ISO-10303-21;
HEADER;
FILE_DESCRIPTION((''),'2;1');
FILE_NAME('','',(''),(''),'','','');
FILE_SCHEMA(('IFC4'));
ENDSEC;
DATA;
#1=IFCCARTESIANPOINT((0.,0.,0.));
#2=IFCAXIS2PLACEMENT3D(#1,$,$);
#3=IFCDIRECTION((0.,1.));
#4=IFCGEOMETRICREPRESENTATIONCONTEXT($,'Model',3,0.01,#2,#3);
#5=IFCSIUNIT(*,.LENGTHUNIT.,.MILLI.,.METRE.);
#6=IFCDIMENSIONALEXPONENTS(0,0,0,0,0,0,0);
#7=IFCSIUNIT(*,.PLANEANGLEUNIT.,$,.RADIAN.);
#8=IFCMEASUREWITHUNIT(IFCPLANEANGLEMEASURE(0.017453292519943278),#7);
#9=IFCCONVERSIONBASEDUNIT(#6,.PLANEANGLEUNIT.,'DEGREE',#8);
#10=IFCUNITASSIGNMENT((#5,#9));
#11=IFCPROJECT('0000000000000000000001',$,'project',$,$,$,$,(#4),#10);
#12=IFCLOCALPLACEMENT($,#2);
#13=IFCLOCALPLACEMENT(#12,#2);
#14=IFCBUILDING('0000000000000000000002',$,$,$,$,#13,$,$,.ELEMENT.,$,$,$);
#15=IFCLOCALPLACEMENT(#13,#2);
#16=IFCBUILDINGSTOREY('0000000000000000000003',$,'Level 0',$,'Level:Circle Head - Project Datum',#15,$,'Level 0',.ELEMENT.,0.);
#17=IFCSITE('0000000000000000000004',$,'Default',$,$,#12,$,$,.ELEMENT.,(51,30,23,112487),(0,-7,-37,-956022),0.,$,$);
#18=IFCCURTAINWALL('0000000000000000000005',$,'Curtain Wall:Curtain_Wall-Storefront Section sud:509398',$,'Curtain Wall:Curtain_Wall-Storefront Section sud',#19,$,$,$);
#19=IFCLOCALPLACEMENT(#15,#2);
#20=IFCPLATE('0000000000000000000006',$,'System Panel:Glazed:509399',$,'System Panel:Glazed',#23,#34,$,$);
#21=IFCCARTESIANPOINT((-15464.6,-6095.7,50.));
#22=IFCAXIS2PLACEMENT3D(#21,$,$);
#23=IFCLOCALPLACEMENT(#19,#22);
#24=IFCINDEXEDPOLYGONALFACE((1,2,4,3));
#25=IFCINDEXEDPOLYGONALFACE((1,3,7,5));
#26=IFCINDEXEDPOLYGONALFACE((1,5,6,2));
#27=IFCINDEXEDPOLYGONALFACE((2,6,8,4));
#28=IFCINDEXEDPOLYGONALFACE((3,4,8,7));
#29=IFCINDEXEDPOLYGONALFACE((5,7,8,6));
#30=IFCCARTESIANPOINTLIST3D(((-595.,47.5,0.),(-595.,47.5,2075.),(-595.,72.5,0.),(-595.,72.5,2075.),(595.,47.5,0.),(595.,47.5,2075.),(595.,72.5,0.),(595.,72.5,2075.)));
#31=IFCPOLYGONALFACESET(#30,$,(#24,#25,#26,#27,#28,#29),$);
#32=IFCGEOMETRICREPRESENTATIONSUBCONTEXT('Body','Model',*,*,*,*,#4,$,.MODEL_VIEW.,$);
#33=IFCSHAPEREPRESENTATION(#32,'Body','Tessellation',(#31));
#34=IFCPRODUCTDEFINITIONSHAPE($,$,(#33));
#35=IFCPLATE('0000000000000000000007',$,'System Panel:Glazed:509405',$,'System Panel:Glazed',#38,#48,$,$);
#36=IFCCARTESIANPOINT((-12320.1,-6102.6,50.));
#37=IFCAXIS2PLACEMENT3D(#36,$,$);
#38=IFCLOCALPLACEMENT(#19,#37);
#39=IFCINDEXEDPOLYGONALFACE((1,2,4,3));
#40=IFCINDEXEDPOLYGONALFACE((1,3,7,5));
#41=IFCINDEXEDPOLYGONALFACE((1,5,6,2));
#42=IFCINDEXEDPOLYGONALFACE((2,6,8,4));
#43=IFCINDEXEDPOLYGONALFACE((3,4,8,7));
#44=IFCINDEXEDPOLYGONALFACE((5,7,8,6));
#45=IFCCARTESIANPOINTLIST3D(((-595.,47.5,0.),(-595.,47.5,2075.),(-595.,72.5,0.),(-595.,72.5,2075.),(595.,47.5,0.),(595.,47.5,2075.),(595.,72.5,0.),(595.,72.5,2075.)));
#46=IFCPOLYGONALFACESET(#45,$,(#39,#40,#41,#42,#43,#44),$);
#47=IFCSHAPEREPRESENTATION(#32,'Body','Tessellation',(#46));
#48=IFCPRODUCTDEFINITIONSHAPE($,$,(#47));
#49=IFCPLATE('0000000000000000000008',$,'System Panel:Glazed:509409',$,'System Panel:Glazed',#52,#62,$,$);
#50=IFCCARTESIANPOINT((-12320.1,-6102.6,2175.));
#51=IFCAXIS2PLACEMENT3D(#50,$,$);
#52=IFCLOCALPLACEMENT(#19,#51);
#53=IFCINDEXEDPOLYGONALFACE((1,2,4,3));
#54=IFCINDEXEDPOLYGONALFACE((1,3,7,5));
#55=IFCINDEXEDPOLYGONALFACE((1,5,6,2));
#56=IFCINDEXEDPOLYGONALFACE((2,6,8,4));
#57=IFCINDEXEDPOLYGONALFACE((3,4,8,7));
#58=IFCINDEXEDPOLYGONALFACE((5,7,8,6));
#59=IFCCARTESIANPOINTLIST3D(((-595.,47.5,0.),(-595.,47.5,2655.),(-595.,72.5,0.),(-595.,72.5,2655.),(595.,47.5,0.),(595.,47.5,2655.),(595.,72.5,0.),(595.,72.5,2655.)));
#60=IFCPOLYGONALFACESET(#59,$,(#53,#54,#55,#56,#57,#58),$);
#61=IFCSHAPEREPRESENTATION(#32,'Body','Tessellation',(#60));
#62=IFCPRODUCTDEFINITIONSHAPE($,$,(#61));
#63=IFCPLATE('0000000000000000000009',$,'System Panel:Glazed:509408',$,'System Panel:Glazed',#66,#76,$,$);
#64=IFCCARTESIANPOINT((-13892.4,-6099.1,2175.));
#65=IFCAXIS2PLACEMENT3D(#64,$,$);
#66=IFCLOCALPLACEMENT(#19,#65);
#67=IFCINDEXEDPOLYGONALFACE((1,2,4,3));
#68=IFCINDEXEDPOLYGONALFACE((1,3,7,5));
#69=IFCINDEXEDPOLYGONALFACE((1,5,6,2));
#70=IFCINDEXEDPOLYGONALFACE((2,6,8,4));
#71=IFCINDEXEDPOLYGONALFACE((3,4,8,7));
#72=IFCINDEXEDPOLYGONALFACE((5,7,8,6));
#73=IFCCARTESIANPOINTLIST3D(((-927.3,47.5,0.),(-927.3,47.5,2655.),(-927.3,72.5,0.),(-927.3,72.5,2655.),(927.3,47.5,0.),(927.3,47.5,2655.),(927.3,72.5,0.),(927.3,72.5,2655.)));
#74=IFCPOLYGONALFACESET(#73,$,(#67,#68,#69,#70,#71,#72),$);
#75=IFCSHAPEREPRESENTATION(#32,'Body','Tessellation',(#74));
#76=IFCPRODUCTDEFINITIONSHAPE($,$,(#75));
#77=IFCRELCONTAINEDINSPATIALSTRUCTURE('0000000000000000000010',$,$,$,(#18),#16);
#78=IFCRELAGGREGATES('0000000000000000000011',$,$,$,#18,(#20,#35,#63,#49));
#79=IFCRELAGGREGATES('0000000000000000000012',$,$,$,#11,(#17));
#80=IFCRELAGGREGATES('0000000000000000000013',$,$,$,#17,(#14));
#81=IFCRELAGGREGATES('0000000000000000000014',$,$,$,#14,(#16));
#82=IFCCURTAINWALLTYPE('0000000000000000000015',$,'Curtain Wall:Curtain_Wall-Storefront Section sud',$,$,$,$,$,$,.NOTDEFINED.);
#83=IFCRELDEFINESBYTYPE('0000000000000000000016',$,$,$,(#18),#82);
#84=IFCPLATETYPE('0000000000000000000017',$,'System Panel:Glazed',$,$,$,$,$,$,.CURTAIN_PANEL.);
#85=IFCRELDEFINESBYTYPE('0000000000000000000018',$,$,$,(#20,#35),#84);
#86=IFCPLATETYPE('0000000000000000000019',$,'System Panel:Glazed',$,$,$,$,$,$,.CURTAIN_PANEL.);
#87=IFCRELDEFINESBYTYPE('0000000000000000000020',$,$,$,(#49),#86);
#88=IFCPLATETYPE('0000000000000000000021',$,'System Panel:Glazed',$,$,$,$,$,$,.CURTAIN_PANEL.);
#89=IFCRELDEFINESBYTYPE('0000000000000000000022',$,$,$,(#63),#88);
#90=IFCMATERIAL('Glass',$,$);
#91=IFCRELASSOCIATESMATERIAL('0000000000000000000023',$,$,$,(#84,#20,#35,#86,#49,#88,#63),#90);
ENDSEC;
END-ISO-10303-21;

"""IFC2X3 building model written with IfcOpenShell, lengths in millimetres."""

from ifc_helpers import new_model, entity, si_unit, converted_unit, direction, frame, frame_2d, origin, origin_2d_with_axis, place, context, subcontext, project, spatial, rectangle, extrude, source, transform, mapped, material, type_object, type_shapes, element, aggregate, save


model = new_model("IFC2X3")

# Units and contexts
model_context = context("Model", 3, precision=0.01, world=origin(), true_north=direction((0.0, 1.0)))
body_context = subcontext(model_context, "Body", "Model", "MODEL_VIEW")
ifc_project = project(units=[si_unit("LENGTHUNIT", "METRE", prefix="MILLI"), converted_unit("PLANEANGLEUNIT", "DEGREE", entity("IfcPlaneAngleMeasure", 0.017453292519943278), si_unit("PLANEANGLEUNIT", "RADIAN"), dimensions=[0, 0, 0, 0, 0, 0, 0])], contexts=[model_context])

# Site, building, storey
site_placement = place(None, origin())
site = spatial("IfcSite", under=ifc_project, at=site_placement, Name="Default", CompositionType="ELEMENT", RefLatitude=(51, 30, 23, 112487), RefLongitude=(0, -7, -37, -956022), RefElevation=0.0)
building_placement = place(site_placement, origin())
building = spatial("IfcBuilding", under=site, at=building_placement, CompositionType="ELEMENT")
storey_placement = place(building_placement, origin())
storey = spatial("IfcBuildingStorey", under=building, at=storey_placement, Name="Level 0", ObjectType="Level:Circle Head - Project Datum", LongName="Level 0", CompositionType="ELEMENT", Elevation=0.0)

# Curtain wall, plates
curtain_wall_type = type_object("IfcCurtainWallType", Name="Curtain Wall:Curtain_Wall-Storefront Section sud", PredefinedType="NOTDEFINED")
curtain_wall_placement = place(storey_placement, origin())
curtain_wall = element("IfcCurtainWall", 1, at=curtain_wall_placement, inside=storey, type_object=curtain_wall_type, Name="Curtain Wall:Curtain_Wall-Storefront Section sud:509398", ObjectType="Curtain Wall:Curtain_Wall-Storefront Section sud")
ifc_material_1 = material(Name="Glass")
plate_type_1 = type_object("IfcPlateType", Name="System Panel:Glazed", PredefinedType="CURTAIN_PANEL", material=ifc_material_1)
shared_shape_1 = source(origin(), body_context, "Body", "SweptSolid", [
    extrude(rectangle(XDim=25.0, YDim=1190.0, at=origin_2d_with_axis()), frame((0.0, 60.0, 0.0), z_axis=(0.0, 0.0, 1.0), x_axis=(0.0, 1.0, 0.0)), (0.0, 0.0, 1.0), 2075.0),
])
type_shapes(plate_type_1, [shared_shape_1])
plate_1_placement = place(curtain_wall_placement, frame((-15464.6, -6095.7, 50.0)))
plate_1 = element("IfcPlate", 2, at=plate_1_placement, type_object=plate_type_1, material=ifc_material_1, Name="System Panel:Glazed:509399", ObjectType="System Panel:Glazed", context=body_context, shape_type="MappedRepresentation", body=[
    mapped(shared_shape_1, transform((0.0, 0.0, 0.0), scale=1.0)),
])
plate_2_placement = place(curtain_wall_placement, frame((-12320.1, -6102.6, 50.0)))
plate_2 = element("IfcPlate", 3, at=plate_2_placement, type_object=plate_type_1, material=ifc_material_1, Name="System Panel:Glazed:509405", ObjectType="System Panel:Glazed", context=body_context, shape_type="MappedRepresentation", body=[
    mapped(shared_shape_1, transform((0.0, 0.0, 0.0), scale=1.0)),
])
plate_type_2 = type_object("IfcPlateType", Name="System Panel:Glazed", PredefinedType="CURTAIN_PANEL", material=ifc_material_1)
shared_shape_2 = source(origin(), body_context, "Body", "SweptSolid", [
    extrude(rectangle(XDim=25.0, YDim=1190.0, at=frame_2d((0.0, 0.0), x_axis=(1.0, 0.0))), frame((0.0, 60.0, 0.0), z_axis=(0.0, 0.0, 1.0), x_axis=(0.0, 1.0, 0.0)), (0.0, 0.0, 1.0), 2655.0),
])
type_shapes(plate_type_2, [shared_shape_2])
plate_3_placement = place(curtain_wall_placement, frame((-12320.1, -6102.6, 2175.0)))
plate_3 = element("IfcPlate", 4, at=plate_3_placement, type_object=plate_type_2, material=ifc_material_1, Name="System Panel:Glazed:509409", ObjectType="System Panel:Glazed", context=body_context, shape_type="MappedRepresentation", body=[
    mapped(shared_shape_2, transform((0.0, 0.0, 0.0), scale=1.0)),
])
plate_type_3 = type_object("IfcPlateType", Name="System Panel:Glazed", PredefinedType="CURTAIN_PANEL", material=ifc_material_1)
shared_shape_3 = source(origin(), body_context, "Body", "SweptSolid", [
    extrude(rectangle(XDim=25.0, YDim=1854.5, at=frame_2d((0.0, 0.0), x_axis=(1.0, 0.0))), frame((0.0, 60.0, 0.0), z_axis=(0.0, 0.0, 1.0), x_axis=(0.0, 1.0, 0.0)), (0.0, 0.0, 1.0), 2655.0),
])
type_shapes(plate_type_3, [shared_shape_3])
plate_4_placement = place(curtain_wall_placement, frame((-13892.4, -6099.1, 2175.0)))
plate_4 = element("IfcPlate", 5, at=plate_4_placement, type_object=plate_type_3, material=ifc_material_1, Name="System Panel:Glazed:509408", ObjectType="System Panel:Glazed", context=body_context, shape_type="MappedRepresentation", body=[
    mapped(shared_shape_3, transform((0.0, 0.0, 0.0), scale=1.0)),
])
aggregate(curtain_wall, [plate_1, plate_2, plate_4, plate_3])

save(model, "model.ifc")
